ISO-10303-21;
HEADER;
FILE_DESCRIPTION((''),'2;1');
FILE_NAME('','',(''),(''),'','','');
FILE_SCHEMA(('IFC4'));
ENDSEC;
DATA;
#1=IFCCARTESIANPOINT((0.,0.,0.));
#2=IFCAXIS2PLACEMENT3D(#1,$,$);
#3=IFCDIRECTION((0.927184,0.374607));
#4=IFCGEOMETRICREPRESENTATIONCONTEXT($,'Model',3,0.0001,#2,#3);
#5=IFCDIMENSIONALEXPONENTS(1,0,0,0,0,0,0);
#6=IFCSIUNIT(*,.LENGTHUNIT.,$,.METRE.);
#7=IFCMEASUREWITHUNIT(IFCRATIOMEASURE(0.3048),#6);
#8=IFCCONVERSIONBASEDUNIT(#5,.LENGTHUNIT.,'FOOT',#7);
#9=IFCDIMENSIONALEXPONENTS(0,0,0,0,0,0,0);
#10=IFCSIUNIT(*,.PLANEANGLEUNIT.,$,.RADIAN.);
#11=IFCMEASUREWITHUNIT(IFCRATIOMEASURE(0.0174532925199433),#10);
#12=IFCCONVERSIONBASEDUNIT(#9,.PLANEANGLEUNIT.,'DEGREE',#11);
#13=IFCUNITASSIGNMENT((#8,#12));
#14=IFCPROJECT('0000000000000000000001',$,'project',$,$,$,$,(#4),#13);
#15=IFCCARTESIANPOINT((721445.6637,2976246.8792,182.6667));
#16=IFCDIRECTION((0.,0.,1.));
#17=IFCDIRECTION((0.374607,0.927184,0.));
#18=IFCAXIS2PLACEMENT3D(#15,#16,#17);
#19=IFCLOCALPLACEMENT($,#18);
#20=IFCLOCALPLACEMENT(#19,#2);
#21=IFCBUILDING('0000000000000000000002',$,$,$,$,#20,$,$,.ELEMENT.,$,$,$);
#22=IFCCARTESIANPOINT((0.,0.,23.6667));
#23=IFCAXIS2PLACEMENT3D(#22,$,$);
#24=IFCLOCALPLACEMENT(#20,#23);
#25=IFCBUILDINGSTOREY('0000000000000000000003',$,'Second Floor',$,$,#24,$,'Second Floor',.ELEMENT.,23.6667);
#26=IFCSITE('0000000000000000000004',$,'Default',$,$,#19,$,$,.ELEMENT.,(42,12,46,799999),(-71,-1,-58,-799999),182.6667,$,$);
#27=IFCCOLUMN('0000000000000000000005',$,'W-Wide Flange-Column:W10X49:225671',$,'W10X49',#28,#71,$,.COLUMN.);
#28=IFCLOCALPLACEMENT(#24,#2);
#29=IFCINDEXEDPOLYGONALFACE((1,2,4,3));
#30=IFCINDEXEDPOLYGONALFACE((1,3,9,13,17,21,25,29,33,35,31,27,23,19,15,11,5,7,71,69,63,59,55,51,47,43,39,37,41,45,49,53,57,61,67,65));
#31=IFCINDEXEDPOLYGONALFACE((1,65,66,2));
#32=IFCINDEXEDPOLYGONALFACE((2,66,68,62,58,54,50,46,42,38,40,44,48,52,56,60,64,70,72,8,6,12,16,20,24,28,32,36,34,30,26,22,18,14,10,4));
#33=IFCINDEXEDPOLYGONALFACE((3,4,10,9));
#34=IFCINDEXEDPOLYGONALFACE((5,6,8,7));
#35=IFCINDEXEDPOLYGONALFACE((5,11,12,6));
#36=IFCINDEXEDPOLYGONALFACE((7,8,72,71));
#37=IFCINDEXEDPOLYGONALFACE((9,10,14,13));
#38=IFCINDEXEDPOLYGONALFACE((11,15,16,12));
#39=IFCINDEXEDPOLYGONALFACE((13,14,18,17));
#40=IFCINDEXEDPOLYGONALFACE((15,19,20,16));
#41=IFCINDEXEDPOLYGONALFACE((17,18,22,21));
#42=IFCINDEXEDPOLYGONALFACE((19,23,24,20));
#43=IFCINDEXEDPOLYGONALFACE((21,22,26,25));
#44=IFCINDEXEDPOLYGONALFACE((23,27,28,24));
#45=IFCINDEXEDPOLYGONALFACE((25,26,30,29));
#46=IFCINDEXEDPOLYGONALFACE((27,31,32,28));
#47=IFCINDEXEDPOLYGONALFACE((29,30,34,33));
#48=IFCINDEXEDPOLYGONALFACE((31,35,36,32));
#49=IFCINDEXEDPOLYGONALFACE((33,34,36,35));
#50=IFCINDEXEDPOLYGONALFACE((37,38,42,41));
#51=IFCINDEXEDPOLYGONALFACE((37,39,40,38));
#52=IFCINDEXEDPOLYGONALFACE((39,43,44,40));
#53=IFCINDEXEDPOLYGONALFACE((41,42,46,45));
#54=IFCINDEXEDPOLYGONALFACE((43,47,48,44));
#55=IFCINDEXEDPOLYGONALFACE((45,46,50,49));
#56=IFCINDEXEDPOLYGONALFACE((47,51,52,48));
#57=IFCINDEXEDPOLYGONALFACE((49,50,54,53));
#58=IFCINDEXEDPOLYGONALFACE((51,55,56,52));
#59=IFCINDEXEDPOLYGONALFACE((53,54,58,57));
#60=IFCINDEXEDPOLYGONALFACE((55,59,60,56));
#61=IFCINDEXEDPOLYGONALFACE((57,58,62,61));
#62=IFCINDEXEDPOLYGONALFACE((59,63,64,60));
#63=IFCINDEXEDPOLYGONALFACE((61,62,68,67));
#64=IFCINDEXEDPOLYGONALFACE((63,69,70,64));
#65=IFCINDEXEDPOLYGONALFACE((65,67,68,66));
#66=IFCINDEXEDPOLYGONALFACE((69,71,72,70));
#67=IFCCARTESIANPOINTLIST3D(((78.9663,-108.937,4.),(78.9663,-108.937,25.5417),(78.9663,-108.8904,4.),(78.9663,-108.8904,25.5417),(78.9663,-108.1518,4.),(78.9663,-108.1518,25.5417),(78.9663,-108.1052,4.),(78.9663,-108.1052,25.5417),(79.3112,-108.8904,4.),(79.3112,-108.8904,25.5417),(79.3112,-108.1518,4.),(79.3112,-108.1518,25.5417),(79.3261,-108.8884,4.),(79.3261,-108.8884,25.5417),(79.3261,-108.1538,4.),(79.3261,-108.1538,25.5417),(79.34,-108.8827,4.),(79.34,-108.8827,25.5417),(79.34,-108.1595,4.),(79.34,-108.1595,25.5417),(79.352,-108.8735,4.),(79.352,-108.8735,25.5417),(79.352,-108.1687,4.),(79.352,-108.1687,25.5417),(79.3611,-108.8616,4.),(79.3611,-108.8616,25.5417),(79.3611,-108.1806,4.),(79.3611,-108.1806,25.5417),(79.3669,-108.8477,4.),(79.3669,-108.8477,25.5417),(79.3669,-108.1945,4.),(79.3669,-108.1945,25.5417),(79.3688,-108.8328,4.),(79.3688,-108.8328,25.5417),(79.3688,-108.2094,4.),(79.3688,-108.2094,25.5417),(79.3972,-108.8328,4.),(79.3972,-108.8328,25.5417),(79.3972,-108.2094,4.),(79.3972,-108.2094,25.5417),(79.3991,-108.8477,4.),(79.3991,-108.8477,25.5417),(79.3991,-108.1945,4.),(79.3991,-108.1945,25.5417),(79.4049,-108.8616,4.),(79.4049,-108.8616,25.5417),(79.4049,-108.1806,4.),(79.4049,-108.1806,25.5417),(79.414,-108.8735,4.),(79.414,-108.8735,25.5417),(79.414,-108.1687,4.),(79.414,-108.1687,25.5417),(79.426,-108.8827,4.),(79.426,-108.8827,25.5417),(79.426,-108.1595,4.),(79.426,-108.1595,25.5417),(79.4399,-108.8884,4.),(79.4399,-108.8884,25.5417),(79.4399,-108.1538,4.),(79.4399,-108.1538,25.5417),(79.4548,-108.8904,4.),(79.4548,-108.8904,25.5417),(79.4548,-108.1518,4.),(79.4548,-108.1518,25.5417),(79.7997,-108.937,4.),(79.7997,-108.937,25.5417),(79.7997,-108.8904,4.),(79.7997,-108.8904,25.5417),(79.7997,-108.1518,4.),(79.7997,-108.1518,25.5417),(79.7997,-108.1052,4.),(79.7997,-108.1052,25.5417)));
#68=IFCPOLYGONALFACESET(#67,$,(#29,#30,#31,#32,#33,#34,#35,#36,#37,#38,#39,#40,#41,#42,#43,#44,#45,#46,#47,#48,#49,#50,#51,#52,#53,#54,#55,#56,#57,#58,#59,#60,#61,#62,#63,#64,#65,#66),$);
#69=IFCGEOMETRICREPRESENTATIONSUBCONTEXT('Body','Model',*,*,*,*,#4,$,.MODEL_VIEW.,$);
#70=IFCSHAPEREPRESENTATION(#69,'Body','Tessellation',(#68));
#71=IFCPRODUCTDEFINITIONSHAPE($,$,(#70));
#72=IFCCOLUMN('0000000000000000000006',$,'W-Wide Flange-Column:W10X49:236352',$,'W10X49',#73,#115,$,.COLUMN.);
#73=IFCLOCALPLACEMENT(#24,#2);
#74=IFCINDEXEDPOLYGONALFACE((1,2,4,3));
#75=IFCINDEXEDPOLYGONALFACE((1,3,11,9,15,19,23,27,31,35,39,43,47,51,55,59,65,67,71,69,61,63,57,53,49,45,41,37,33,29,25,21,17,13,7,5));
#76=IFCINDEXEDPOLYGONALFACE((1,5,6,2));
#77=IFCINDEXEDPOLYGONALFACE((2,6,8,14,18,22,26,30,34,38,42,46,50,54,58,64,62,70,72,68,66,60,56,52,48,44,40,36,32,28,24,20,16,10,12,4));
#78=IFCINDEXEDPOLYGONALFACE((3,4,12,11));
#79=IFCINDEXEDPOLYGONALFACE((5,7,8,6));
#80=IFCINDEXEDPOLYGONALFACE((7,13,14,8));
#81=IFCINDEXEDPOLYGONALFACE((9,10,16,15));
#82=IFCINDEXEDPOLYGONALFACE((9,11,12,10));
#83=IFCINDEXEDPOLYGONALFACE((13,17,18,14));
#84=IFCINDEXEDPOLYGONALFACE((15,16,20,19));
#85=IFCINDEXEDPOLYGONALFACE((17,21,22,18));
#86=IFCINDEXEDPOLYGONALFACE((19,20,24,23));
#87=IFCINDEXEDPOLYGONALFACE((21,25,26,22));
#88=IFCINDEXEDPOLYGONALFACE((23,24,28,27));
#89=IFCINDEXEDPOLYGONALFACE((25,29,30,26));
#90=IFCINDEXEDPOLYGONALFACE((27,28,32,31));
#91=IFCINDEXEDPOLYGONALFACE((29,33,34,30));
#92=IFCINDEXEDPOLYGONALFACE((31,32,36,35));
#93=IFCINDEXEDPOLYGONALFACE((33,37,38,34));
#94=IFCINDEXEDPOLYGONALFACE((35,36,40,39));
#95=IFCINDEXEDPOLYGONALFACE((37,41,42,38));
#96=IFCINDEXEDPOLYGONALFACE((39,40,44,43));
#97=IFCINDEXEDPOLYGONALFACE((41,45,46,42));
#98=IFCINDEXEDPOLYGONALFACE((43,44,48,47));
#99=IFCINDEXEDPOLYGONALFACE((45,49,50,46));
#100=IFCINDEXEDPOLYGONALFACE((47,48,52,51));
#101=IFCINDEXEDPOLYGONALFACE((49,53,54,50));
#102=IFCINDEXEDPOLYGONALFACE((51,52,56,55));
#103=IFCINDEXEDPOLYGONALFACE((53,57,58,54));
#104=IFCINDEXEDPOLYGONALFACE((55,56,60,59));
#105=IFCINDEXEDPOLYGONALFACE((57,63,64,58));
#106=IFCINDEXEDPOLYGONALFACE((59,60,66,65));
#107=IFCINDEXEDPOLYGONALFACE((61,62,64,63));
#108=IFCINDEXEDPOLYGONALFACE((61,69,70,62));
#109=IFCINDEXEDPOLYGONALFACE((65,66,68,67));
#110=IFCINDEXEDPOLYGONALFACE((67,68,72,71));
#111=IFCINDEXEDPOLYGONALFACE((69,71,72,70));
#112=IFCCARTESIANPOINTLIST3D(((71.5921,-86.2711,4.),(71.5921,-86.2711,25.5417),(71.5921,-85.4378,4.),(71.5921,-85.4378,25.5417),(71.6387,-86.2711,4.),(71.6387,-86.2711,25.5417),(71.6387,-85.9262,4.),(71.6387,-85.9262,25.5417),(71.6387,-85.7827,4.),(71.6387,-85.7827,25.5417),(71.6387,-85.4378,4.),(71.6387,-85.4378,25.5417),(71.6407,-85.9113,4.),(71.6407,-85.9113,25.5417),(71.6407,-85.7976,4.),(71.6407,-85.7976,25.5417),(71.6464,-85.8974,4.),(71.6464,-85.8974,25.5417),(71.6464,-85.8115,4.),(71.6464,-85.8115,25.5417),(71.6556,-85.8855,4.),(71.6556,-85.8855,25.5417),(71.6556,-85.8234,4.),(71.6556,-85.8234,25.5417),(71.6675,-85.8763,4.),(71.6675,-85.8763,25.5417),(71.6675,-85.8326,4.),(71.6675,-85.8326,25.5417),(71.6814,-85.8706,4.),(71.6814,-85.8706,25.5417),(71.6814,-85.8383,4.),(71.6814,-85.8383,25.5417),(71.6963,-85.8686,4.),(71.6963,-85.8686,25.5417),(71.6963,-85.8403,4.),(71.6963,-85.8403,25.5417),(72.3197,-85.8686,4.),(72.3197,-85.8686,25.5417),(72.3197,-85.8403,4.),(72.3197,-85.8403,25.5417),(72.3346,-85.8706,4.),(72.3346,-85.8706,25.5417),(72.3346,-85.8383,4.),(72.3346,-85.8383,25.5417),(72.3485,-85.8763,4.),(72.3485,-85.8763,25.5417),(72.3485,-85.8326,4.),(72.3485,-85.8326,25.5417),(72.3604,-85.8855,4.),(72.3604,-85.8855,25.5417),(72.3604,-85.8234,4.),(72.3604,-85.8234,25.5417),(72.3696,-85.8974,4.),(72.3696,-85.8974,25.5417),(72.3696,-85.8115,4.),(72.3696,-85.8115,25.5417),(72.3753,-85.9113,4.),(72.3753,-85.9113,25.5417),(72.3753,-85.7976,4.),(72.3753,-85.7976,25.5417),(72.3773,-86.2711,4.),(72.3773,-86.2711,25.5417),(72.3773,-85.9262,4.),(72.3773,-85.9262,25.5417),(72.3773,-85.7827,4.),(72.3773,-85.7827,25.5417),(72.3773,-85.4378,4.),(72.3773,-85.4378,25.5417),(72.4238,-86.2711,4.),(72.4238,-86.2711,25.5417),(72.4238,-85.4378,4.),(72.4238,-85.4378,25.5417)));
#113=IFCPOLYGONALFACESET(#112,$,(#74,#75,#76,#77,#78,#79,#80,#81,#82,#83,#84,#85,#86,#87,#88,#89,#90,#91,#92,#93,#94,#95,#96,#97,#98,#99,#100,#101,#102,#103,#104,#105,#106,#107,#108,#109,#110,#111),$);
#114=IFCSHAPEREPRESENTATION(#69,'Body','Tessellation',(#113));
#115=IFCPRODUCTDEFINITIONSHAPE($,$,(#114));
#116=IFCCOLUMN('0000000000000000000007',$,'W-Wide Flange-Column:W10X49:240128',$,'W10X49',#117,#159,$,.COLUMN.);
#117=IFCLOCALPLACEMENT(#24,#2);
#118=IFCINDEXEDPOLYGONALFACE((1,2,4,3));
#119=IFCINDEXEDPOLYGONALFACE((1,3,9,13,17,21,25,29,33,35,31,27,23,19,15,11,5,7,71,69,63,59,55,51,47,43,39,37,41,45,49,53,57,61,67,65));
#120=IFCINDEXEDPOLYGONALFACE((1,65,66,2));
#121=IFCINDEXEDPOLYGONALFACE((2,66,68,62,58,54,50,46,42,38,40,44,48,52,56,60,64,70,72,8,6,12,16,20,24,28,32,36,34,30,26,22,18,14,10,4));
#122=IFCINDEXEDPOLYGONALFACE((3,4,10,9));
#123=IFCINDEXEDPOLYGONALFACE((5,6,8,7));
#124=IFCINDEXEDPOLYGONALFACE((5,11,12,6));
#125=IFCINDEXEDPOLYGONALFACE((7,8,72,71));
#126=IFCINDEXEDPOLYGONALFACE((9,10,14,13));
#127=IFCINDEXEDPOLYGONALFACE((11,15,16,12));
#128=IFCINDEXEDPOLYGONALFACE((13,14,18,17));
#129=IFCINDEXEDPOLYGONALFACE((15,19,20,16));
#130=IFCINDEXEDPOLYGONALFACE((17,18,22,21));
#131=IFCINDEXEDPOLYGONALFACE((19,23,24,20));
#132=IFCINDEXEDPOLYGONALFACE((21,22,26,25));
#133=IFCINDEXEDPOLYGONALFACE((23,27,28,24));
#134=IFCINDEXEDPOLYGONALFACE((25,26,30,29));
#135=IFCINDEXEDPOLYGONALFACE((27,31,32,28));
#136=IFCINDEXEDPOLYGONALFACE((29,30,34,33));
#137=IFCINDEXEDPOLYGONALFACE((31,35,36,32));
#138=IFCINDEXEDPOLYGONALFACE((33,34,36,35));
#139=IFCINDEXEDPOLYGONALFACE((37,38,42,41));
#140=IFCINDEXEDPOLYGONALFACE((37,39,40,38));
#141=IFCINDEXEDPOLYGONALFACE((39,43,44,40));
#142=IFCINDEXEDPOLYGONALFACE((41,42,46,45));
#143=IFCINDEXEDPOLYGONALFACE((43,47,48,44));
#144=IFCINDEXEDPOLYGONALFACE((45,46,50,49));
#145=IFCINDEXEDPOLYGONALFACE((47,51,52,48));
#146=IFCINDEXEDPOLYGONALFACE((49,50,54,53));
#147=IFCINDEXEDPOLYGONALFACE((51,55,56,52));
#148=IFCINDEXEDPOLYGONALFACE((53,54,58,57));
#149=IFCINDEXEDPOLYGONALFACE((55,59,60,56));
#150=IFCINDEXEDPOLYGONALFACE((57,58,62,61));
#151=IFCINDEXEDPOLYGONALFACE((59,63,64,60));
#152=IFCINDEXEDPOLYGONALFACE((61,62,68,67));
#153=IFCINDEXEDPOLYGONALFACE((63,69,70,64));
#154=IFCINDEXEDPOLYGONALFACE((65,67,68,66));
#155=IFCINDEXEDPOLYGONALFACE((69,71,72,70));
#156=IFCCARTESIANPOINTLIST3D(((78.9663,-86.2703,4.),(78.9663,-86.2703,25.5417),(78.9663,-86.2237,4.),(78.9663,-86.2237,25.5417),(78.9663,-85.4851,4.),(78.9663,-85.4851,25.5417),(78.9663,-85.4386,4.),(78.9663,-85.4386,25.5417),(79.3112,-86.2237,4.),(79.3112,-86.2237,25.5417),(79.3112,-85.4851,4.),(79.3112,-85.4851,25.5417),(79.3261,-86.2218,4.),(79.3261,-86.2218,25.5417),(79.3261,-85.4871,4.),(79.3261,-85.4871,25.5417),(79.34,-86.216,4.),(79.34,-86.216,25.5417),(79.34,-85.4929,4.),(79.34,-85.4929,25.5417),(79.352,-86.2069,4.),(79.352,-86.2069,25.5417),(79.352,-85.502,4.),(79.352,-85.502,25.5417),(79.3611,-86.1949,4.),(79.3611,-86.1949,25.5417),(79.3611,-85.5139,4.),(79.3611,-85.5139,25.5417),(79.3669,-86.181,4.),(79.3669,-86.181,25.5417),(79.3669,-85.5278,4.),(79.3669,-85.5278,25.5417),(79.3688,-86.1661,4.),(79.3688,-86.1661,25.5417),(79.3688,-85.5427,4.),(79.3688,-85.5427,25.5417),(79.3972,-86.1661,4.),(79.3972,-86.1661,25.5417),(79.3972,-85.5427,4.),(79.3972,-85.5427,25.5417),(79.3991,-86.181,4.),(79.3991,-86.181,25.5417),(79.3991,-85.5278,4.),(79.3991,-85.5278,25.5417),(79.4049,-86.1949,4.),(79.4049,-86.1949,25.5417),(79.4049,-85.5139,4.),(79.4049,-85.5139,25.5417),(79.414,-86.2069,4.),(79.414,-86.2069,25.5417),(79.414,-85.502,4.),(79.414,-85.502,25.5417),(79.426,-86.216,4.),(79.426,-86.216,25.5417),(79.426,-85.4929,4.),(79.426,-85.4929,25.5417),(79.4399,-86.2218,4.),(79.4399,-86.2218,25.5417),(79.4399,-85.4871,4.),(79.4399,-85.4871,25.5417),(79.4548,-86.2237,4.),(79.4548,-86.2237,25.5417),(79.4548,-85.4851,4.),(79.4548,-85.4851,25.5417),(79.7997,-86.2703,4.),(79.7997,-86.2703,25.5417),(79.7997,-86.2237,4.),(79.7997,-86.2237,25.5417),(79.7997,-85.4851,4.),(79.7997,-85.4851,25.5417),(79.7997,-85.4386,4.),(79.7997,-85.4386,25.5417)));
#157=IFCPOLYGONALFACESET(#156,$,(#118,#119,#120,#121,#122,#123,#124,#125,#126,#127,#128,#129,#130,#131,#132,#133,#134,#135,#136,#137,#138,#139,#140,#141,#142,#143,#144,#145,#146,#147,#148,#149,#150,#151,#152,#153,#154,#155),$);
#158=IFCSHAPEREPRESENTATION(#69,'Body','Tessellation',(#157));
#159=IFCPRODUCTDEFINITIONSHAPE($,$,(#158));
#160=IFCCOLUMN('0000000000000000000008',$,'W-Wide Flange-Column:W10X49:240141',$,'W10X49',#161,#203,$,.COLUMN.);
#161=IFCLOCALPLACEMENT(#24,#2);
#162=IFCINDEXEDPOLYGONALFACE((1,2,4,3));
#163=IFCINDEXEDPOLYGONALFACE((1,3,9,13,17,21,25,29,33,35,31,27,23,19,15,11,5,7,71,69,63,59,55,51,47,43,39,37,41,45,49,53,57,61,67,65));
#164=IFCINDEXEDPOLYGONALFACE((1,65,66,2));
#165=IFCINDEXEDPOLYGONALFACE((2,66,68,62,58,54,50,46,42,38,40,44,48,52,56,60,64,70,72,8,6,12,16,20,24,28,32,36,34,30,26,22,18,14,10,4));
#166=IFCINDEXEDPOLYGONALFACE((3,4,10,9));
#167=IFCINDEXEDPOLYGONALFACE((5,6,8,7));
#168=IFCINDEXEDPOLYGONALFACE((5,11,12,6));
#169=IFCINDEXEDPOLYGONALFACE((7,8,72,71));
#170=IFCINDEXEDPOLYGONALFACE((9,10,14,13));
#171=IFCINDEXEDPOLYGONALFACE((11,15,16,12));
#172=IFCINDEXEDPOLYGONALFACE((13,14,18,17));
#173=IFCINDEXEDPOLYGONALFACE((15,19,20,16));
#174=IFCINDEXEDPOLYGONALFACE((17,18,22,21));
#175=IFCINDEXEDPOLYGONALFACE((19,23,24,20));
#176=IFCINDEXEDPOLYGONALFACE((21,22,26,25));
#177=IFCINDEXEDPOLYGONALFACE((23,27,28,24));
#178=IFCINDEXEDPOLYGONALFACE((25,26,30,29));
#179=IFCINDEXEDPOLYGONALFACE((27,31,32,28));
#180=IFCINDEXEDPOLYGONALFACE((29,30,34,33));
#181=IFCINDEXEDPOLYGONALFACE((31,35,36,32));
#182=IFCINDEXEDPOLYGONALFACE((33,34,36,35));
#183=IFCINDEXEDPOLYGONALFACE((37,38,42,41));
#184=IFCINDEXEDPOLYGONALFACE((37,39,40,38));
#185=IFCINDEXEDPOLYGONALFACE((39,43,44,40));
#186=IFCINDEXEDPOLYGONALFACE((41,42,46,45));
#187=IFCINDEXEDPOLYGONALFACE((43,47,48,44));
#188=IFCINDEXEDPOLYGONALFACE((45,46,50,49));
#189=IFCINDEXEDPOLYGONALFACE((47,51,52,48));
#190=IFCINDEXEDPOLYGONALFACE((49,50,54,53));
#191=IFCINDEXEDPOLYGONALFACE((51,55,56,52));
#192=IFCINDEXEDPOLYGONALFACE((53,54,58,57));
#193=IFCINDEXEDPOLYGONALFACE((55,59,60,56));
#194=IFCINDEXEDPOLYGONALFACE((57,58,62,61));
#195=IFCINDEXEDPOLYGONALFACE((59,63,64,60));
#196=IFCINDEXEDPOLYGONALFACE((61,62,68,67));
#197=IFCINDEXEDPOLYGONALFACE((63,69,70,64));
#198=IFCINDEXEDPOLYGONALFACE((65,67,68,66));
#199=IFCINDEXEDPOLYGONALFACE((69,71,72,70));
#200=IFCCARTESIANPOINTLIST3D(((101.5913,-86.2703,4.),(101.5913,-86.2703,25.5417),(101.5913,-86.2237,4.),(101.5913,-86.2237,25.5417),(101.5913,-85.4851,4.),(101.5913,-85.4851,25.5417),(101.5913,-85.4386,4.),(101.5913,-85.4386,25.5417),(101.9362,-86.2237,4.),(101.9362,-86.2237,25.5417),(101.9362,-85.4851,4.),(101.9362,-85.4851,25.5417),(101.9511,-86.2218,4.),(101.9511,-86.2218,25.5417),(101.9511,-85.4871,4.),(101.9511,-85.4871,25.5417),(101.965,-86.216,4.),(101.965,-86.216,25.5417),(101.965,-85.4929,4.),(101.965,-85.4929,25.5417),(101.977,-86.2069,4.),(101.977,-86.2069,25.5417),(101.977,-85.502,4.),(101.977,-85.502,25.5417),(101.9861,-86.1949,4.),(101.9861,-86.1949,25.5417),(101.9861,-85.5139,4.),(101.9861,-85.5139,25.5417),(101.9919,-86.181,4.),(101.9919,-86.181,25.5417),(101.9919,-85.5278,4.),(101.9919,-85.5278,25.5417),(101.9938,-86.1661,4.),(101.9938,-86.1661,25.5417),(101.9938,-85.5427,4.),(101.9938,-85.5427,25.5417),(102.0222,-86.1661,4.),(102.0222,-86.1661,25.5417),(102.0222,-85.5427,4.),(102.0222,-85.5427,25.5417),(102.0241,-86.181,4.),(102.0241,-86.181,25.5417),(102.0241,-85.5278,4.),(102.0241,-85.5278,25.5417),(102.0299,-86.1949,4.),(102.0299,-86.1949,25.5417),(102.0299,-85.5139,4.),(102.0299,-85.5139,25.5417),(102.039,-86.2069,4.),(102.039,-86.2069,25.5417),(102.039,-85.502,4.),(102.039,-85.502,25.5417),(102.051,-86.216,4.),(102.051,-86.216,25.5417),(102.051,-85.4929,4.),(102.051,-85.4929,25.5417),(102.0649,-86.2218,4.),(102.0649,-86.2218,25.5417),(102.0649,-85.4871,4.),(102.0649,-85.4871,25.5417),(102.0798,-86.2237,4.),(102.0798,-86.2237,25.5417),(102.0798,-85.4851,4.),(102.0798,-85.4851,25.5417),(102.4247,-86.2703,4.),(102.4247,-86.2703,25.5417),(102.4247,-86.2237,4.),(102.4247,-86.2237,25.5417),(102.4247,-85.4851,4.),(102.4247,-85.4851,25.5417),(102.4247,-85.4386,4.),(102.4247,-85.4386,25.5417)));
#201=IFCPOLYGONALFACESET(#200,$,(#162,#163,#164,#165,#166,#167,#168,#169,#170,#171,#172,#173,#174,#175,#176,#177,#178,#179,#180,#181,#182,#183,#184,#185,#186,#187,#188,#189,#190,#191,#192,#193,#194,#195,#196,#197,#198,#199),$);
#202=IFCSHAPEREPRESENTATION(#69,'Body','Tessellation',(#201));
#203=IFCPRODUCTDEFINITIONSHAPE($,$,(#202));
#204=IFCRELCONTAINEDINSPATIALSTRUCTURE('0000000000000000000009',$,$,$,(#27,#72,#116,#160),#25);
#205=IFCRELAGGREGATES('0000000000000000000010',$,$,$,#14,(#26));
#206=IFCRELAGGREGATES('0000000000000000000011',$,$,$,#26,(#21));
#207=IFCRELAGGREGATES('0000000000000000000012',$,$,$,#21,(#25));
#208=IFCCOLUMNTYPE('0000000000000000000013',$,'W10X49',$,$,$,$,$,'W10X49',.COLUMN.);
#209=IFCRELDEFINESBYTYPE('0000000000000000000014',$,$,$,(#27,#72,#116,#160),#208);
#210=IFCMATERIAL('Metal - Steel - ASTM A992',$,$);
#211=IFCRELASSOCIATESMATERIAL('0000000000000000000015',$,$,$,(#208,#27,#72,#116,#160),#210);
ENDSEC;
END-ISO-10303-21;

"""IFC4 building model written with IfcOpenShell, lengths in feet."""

from ifc_helpers import new_model, entity, si_unit, converted_unit, direction, frame, frame_2d, origin, place, context, subcontext, project, spatial, i_section, extrude, source, transform, mapped, material, type_object, type_shapes, element, save


model = new_model("IFC4")

# Units and contexts
model_context = context("Model", 3, precision=0.0001, world=origin(), true_north=direction((0.927184, 0.374607)))
body_context = subcontext(model_context, "Body", "Model", "MODEL_VIEW")
ifc_project = project(units=[converted_unit("LENGTHUNIT", "FOOT", entity("IfcRatioMeasure", 0.3048), si_unit("LENGTHUNIT", "METRE"), dimensions=[1, 0, 0, 0, 0, 0, 0]), converted_unit("PLANEANGLEUNIT", "DEGREE", entity("IfcRatioMeasure", 0.0174532925199433), si_unit("PLANEANGLEUNIT", "RADIAN"), dimensions=[0, 0, 0, 0, 0, 0, 0])], contexts=[model_context])

# Site, building, storey
site_placement = place(None, frame((721445.6637, 2976246.8792, 182.6667), z_axis=(0.0, 0.0, 1.0), x_axis=(0.374607, 0.927184, 0.0)))
site = spatial("IfcSite", under=ifc_project, at=site_placement, Name="Default", CompositionType="ELEMENT", RefLatitude=(42, 12, 46, 799999), RefLongitude=(-71, -1, -58, -799999), RefElevation=182.6667)
building_placement = place(site_placement, origin())
building = spatial("IfcBuilding", under=site, at=building_placement, CompositionType="ELEMENT")
storey_placement = place(building_placement, frame((0.0, 0.0, 23.6667)))
storey = spatial("IfcBuildingStorey", under=building, at=storey_placement, Name="Second Floor", LongName="Second Floor", CompositionType="ELEMENT", Elevation=23.6667)

# Columns
ifc_material_1 = material(Name="Metal - Steel - ASTM A992")
column_type = type_object("IfcColumnType", Name="W10X49", ElementType="W10X49", PredefinedType="COLUMN", material=ifc_material_1)
shared_shape_1 = source(origin(), body_context, "Body", "SweptSolid", [
    extrude(i_section(OverallWidth=0.8333, OverallDepth=0.8317, WebThickness=0.0283, FlangeThickness=0.0465, FilletRadius=0.0576, at=frame_2d((0.0, 0.0), x_axis=(0.0, 1.0))), frame((0.0, 0.0, 27.6667), z_axis=(0.0, 0.0, 1.0), x_axis=(0.0, -1.0, 0.0)), (0.0, 0.0, 1.0), 21.5417),
])
type_shapes(column_type, [shared_shape_1])
column_1_placement = place(storey_placement, frame((79.383, -108.5211, -23.6667)))
element("IfcColumn", 1, at=column_1_placement, inside=storey, type_object=column_type, material=ifc_material_1, Name="W-Wide Flange-Column:W10X49:225671", ObjectType="W10X49", PredefinedType="COLUMN", context=body_context, shape_type="MappedRepresentation", body=[
    mapped(shared_shape_1, transform((0.0, 0.0, 0.0), scale=1.0)),
])
column_2_placement = place(storey_placement, frame((72.008, -85.8544, -23.6667), z_axis=(0.0, 0.0, 1.0), x_axis=(0.0, 1.0, 0.0)))
element("IfcColumn", 2, at=column_2_placement, inside=storey, type_object=column_type, material=ifc_material_1, Name="W-Wide Flange-Column:W10X49:236352", ObjectType="W10X49", PredefinedType="COLUMN", context=body_context, shape_type="MappedRepresentation", body=[
    mapped(shared_shape_1, transform((0.0, 0.0, 0.0), scale=1.0)),
])
for number, where, name in (
    (3, (79.383, -85.8544, -23.6667), "W-Wide Flange-Column:W10X49:240128"),
    (4, (102.008, -85.8544, -23.6667), "W-Wide Flange-Column:W10X49:240141"),
):
    element("IfcColumn", number, at=place(storey_placement, frame(where)), inside=storey, type_object=column_type, material=ifc_material_1, Name=name, ObjectType="W10X49", PredefinedType="COLUMN", context=body_context, shape_type="MappedRepresentation", body=[
        mapped(shared_shape_1, transform((0.0, 0.0, 0.0), scale=1.0)),
    ])

save(model, "model.ifc")
